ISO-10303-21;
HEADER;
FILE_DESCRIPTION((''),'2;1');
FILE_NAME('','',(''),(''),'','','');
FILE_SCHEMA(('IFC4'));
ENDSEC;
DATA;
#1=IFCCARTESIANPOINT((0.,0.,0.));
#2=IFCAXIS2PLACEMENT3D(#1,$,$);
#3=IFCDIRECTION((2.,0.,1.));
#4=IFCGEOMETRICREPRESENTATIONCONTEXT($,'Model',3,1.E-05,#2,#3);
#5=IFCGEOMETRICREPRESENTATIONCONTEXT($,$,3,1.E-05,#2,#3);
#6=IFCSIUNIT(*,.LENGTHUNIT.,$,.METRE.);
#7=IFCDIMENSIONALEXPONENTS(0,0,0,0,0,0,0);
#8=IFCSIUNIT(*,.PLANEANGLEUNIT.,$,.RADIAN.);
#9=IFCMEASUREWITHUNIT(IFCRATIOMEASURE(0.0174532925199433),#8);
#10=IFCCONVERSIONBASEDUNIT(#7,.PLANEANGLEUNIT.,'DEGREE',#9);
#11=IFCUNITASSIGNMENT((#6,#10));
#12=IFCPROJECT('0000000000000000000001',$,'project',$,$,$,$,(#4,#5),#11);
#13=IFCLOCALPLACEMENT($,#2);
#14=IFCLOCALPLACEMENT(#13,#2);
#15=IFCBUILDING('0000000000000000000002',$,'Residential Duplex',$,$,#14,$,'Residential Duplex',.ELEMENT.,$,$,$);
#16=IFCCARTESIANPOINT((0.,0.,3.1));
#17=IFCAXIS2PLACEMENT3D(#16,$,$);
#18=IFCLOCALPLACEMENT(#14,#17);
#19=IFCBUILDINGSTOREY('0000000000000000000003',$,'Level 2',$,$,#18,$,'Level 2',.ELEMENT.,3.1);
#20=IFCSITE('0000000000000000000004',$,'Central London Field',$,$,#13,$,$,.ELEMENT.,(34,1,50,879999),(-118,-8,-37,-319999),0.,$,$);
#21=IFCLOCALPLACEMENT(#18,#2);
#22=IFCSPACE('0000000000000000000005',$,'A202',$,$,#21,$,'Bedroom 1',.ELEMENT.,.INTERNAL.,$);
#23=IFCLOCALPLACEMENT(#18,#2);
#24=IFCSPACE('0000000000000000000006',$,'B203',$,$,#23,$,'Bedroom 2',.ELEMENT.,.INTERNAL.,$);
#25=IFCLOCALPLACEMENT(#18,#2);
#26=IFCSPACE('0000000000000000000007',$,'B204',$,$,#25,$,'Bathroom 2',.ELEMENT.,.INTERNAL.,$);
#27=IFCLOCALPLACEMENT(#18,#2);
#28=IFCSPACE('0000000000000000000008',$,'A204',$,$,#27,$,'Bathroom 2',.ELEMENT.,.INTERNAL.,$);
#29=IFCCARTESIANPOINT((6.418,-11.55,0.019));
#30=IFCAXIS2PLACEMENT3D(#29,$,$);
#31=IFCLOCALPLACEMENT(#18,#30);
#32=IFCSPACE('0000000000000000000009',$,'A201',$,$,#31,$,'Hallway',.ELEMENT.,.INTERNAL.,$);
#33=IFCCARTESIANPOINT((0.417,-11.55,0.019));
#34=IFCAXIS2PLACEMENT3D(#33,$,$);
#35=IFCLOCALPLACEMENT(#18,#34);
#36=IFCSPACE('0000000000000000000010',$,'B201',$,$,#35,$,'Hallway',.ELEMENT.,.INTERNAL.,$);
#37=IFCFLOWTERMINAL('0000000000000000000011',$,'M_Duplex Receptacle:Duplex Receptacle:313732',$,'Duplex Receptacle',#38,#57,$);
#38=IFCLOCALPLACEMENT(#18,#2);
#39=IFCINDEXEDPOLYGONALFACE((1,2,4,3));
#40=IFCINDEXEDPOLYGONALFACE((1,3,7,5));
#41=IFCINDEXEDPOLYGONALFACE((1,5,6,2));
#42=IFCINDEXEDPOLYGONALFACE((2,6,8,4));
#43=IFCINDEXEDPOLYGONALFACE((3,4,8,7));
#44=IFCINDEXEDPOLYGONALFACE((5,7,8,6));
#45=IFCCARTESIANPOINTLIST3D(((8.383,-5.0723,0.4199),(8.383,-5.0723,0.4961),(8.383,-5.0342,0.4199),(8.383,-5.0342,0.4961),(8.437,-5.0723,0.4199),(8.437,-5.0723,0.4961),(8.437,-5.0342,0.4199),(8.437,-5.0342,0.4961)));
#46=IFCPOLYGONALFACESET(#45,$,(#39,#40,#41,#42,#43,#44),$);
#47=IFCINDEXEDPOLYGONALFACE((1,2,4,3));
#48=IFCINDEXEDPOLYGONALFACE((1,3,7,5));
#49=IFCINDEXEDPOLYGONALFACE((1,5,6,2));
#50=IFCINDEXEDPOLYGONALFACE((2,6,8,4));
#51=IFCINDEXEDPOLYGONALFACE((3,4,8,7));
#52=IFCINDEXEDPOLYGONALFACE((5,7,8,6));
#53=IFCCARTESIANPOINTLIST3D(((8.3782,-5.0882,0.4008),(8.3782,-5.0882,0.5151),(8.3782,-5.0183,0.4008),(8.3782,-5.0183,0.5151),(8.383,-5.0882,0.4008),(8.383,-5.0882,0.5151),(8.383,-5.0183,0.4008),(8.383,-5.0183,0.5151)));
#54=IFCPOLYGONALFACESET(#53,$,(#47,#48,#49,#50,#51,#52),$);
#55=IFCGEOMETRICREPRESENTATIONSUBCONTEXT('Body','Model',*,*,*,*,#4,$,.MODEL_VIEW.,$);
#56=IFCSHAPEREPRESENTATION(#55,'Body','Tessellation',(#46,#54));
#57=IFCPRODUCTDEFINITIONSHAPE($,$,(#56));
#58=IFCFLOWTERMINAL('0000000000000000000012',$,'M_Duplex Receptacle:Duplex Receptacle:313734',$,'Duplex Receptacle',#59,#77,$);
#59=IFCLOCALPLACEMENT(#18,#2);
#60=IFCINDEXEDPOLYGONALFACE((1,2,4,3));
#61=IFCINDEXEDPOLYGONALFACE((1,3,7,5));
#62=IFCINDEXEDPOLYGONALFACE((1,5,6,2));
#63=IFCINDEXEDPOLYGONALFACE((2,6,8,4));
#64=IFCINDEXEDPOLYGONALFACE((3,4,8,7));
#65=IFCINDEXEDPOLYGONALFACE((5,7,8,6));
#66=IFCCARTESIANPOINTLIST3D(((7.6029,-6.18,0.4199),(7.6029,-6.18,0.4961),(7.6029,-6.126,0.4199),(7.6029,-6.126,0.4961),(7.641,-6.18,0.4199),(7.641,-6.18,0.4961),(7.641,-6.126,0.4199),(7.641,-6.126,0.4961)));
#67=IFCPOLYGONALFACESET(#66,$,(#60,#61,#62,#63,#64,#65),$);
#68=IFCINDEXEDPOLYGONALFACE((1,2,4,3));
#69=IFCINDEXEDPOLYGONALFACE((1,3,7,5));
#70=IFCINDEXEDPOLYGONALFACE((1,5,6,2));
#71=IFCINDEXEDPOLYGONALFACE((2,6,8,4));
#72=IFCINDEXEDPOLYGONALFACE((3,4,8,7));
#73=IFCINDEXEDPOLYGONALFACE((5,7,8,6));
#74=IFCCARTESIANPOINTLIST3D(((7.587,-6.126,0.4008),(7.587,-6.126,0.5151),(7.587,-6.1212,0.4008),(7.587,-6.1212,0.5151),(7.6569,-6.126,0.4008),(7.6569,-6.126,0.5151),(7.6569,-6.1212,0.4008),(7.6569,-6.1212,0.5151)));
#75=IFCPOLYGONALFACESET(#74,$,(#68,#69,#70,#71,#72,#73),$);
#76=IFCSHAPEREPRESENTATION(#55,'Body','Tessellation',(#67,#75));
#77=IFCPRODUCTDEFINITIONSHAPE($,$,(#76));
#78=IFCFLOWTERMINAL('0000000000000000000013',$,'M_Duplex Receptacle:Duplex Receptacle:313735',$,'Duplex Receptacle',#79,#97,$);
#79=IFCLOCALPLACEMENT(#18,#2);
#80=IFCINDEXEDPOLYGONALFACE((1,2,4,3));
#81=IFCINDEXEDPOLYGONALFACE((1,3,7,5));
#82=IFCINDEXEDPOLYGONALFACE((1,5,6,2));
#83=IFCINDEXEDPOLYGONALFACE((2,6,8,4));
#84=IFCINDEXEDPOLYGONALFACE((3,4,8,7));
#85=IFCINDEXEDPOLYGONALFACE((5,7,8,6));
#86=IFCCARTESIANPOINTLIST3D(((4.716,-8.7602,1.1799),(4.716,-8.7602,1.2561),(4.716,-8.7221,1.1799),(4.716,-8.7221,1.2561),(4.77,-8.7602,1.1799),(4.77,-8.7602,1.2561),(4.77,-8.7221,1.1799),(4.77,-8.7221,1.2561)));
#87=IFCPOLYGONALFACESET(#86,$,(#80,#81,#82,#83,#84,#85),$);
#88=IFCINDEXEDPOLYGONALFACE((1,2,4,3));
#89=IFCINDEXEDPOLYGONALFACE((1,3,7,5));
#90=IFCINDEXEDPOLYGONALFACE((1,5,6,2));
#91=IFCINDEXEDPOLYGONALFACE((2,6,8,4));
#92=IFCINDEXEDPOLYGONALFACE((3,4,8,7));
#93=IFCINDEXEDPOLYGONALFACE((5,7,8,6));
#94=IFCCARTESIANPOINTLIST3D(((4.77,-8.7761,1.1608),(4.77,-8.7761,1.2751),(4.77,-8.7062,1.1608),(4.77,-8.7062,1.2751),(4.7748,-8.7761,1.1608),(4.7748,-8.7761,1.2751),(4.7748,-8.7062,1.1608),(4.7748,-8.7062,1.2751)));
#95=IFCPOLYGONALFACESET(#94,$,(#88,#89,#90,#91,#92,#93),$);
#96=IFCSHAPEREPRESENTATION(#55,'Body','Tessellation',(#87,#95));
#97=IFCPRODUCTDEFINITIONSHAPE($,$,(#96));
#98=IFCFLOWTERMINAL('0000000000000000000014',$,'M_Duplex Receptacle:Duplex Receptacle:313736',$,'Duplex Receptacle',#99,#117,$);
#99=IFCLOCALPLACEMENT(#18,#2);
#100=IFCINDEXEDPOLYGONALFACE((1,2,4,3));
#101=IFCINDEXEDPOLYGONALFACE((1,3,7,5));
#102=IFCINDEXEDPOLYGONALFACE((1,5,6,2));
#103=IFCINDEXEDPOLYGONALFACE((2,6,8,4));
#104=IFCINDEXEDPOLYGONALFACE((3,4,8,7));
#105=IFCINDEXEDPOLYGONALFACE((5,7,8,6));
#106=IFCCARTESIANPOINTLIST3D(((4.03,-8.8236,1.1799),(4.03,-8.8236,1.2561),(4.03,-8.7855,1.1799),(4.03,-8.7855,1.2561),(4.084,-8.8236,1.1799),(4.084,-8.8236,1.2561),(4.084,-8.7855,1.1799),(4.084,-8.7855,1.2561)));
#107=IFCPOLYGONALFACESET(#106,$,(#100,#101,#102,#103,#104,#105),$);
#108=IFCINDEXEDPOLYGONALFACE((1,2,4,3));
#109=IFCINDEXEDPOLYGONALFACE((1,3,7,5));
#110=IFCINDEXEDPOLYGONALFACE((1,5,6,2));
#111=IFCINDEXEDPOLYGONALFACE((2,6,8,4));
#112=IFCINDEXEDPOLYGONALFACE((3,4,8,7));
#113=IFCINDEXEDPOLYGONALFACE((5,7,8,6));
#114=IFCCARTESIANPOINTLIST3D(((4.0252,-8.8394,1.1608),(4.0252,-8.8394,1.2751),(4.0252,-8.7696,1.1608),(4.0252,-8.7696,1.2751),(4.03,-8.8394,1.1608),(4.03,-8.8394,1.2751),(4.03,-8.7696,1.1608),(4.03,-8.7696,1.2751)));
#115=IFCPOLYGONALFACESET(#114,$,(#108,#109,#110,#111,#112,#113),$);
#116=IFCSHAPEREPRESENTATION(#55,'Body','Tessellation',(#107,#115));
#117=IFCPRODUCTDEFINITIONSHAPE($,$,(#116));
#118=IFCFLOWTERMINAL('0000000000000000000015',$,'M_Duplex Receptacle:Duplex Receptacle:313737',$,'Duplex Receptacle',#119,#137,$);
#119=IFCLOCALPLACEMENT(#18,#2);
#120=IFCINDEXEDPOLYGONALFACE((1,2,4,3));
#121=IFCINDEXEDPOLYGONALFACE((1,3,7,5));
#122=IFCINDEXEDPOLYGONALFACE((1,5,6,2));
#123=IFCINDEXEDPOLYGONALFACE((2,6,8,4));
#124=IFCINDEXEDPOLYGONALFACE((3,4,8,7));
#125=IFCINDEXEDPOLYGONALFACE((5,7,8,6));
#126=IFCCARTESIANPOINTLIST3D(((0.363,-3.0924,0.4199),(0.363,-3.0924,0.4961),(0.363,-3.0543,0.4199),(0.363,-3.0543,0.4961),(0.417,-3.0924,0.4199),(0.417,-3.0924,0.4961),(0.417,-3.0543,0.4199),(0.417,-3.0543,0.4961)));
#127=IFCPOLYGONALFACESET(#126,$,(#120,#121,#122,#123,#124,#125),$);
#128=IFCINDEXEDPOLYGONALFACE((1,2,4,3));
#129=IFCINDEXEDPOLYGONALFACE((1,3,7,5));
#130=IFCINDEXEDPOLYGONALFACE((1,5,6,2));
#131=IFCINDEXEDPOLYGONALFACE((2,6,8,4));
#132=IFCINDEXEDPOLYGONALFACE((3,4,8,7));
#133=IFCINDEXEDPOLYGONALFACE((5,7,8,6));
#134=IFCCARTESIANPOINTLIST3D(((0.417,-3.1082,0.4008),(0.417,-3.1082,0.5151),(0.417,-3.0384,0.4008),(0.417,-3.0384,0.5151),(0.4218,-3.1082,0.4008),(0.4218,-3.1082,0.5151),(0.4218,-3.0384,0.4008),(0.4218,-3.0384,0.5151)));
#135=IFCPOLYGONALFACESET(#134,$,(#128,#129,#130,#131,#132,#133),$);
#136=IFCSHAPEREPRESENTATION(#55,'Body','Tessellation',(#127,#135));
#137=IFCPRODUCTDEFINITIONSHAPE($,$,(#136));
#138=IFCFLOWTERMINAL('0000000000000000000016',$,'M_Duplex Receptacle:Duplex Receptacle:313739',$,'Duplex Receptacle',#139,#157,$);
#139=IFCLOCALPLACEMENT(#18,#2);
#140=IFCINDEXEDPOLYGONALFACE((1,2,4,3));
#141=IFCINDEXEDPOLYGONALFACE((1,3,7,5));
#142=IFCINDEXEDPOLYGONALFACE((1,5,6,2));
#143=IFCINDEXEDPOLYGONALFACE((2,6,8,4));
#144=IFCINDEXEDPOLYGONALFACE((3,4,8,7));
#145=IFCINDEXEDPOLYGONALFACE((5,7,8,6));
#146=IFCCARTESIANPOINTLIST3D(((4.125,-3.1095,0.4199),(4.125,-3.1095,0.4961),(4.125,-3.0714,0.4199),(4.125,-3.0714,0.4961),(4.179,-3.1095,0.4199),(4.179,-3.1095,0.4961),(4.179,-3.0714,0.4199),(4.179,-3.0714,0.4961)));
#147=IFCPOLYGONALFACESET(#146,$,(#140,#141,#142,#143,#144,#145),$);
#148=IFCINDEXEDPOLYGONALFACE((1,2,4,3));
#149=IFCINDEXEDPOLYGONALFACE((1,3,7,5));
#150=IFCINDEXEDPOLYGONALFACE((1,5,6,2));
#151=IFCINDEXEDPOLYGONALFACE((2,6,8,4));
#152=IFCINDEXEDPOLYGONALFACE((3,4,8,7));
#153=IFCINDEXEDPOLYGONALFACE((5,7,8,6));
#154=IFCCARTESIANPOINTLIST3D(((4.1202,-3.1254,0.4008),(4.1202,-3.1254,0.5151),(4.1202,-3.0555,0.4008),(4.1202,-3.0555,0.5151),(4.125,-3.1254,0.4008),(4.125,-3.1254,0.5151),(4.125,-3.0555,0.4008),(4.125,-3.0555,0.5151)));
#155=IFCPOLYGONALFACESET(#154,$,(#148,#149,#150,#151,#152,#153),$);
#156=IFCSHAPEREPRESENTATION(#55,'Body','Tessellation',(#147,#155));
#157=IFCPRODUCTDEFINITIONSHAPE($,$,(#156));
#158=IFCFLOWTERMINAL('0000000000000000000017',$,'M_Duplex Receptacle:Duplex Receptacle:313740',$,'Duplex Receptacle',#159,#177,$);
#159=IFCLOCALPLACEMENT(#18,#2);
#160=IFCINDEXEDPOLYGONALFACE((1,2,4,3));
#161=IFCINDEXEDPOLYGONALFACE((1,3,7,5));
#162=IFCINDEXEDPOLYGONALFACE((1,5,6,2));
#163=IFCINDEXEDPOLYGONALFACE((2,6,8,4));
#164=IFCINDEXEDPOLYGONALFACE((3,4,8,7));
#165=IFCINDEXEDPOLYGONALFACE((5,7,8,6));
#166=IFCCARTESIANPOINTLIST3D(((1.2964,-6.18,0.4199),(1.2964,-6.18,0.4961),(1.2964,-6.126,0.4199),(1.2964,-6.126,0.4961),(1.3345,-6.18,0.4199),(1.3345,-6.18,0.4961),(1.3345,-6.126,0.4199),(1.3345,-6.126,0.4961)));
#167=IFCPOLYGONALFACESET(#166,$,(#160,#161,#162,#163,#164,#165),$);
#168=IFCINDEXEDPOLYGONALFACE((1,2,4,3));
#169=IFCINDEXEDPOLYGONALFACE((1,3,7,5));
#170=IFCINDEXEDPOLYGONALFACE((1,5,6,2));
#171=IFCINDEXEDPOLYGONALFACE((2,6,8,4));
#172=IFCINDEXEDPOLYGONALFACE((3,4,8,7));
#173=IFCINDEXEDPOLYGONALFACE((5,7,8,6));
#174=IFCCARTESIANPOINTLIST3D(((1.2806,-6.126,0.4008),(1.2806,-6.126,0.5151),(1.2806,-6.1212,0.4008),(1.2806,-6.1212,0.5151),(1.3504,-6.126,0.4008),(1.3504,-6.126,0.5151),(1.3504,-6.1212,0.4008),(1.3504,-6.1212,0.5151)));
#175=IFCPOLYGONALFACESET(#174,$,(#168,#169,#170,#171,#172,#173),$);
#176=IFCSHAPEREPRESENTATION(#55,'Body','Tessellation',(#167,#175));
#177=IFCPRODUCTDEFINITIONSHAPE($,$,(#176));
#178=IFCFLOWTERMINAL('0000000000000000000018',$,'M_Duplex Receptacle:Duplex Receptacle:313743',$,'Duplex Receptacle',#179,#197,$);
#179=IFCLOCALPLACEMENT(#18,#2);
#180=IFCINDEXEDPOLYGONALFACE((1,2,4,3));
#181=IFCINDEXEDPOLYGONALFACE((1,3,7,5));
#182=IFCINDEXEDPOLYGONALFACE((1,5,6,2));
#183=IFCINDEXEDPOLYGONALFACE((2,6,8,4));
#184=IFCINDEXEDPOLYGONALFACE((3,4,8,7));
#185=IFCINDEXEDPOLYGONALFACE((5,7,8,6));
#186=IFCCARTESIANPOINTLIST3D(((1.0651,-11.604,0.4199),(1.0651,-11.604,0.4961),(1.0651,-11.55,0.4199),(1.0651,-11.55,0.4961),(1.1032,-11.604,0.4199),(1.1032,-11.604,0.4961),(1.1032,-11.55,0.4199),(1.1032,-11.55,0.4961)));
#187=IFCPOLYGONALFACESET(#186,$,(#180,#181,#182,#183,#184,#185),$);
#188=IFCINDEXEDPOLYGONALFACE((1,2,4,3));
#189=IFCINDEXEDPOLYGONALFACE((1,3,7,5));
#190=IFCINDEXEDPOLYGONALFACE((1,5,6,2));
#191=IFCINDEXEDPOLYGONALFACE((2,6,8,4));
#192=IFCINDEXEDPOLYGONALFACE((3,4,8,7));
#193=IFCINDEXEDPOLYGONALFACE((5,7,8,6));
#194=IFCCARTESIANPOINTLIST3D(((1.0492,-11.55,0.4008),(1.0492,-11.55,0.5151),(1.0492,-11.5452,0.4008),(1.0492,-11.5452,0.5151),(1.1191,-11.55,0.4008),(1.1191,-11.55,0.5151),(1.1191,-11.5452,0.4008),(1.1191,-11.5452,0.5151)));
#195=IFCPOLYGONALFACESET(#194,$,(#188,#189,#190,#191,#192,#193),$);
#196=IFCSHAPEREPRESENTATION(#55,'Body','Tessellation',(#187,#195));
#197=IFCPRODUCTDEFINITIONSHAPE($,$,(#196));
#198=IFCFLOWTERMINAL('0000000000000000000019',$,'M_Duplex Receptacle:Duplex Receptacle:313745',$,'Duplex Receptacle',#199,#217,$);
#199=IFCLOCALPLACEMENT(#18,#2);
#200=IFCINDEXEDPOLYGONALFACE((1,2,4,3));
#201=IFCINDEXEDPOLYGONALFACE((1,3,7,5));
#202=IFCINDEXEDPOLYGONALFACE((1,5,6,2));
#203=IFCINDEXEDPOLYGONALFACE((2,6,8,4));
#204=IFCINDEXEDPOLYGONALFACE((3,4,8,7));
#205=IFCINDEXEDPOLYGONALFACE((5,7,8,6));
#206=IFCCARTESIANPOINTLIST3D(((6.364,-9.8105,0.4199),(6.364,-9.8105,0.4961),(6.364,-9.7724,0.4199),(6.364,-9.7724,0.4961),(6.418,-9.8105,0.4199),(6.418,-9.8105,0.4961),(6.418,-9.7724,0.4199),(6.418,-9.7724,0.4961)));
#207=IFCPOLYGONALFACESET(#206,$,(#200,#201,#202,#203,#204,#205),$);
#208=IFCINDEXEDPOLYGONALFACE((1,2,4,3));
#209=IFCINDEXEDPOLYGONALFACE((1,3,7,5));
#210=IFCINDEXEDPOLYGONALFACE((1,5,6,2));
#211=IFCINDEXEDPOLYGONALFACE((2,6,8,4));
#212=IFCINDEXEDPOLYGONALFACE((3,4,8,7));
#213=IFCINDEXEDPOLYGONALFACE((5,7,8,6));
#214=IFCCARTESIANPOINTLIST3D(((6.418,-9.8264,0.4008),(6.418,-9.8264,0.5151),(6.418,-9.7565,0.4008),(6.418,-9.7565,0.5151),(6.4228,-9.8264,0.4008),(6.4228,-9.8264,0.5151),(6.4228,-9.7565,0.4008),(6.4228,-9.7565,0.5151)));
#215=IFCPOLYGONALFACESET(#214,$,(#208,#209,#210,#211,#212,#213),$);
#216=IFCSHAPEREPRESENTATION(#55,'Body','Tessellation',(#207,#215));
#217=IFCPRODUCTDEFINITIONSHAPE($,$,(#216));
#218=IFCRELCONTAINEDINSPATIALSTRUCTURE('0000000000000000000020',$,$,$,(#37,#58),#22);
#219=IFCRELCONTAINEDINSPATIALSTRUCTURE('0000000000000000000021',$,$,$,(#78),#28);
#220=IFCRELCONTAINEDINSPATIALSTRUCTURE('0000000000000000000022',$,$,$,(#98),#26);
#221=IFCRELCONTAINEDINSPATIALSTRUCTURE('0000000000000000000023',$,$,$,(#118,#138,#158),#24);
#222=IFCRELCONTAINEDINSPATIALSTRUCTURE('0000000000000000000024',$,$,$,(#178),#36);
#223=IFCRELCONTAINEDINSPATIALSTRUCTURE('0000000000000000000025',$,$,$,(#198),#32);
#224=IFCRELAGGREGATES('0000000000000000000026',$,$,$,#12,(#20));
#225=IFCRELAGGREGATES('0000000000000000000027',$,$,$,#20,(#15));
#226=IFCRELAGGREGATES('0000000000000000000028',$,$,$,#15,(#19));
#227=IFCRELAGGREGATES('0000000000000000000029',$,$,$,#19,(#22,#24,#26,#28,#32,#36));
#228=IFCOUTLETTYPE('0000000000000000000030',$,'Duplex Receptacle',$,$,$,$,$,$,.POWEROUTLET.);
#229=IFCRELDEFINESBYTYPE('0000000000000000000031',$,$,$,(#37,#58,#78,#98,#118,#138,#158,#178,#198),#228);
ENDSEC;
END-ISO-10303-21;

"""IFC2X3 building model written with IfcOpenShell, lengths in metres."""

from ifc_helpers import new_model, entity, si_unit, converted_unit, direction, frame, frame_2d, origin, origin_2d_with_axis, place, context, subcontext, project, spatial, rectangle, extrude, source, transform, mapped, type_object, type_shapes, element, save


model = new_model("IFC2X3")

# Units and contexts
model_context = context("Model", 3, precision=1e-05, world=origin(), true_north=direction((2.0, 0.0, 1.0)))
context_of_model = context(None, 3, precision=1e-05, world=origin(), true_north=direction((2.0, 0.0, 1.0)))
body_context = subcontext(model_context, "Body", "Model", "MODEL_VIEW")
ifc_project = project(units=[si_unit("LENGTHUNIT", "METRE"), converted_unit("PLANEANGLEUNIT", "DEGREE", entity("IfcRatioMeasure", 0.0174532925199433), si_unit("PLANEANGLEUNIT", "RADIAN"), dimensions=[0, 0, 0, 0, 0, 0, 0])], contexts=[model_context, context_of_model])

# Site, building, storey, space
site_placement = place(None, origin())
site = spatial("IfcSite", under=ifc_project, at=site_placement, Name="Central London Field", CompositionType="ELEMENT", RefLatitude=(34, 1, 50, 879999), RefLongitude=(-118, -8, -37, -319999), RefElevation=0.0)
building_placement = place(site_placement, origin())
building = spatial("IfcBuilding", under=site, at=building_placement, Name="Residential Duplex", LongName="Residential Duplex", CompositionType="ELEMENT")
storey_placement = place(building_placement, frame((0.0, 0.0, 3.1)))
storey = spatial("IfcBuildingStorey", under=building, at=storey_placement, Name="Level 2", LongName="Level 2", CompositionType="ELEMENT", Elevation=3.1)
space_1_placement = place(storey_placement, origin())
space_1 = spatial("IfcSpace", under=storey, at=space_1_placement, Name="A202", LongName="Bedroom 1", CompositionType="ELEMENT", InteriorOrExteriorSpace="INTERNAL")

# Shared definitions
space_2_placement = place(storey_placement, origin())
space_2 = spatial("IfcSpace", under=storey, at=space_2_placement, Name="B203", LongName="Bedroom 2", CompositionType="ELEMENT", InteriorOrExteriorSpace="INTERNAL")

# Shared definitions
space_3_placement = place(storey_placement, origin())
space_3 = spatial("IfcSpace", under=storey, at=space_3_placement, Name="B204", LongName="Bathroom 2", CompositionType="ELEMENT", InteriorOrExteriorSpace="INTERNAL")

# Shared definitions
space_4_placement = place(storey_placement, origin())
space_4 = spatial("IfcSpace", under=storey, at=space_4_placement, Name="A204", LongName="Bathroom 2", CompositionType="ELEMENT", InteriorOrExteriorSpace="INTERNAL")

# Shared definitions
space_5_placement = place(storey_placement, frame((6.418, -11.55, 0.019)))
space_5 = spatial("IfcSpace", under=storey, at=space_5_placement, Name="A201", LongName="Hallway", CompositionType="ELEMENT", InteriorOrExteriorSpace="INTERNAL")

# Shared definitions
space_6_placement = place(storey_placement, frame((0.417, -11.55, 0.019)))
space_6 = spatial("IfcSpace", under=storey, at=space_6_placement, Name="B201", LongName="Hallway", CompositionType="ELEMENT", InteriorOrExteriorSpace="INTERNAL")

# Flow terminals
outlet_type = type_object("IfcOutletType", Name="Duplex Receptacle", PredefinedType="POWEROUTLET")
shared_shape_1 = source(origin(), body_context, "Body", "SweptSolid", [
    extrude(rectangle(XDim=0.0381, YDim=0.0762, at=origin_2d_with_axis()), frame((0.0, 0.0, -0.054), z_axis=(0.0, 0.0, 1.0), x_axis=(-1.0, 0.0, 0.0)), (0.0, 0.0, 1.0), 0.054),
    extrude(rectangle(XDim=0.0698, YDim=0.1143, at=frame_2d((0.0, 0.0), x_axis=(1.0, 0.0))), frame((0.0, 0.0, 0.0), z_axis=(0.0, 0.0, 1.0), x_axis=(-1.0, 0.0, 0.0)), (0.0, 0.0, 1.0), 0.0048),
])
type_shapes(outlet_type, [shared_shape_1])
for number, where, z_axis, x_axis, name in (
    (1, (8.383, -5.0533, 0.458), (-1.0, 0.0, 0.0), (0.0, -1.0, 0.0), "M_Duplex Receptacle:Duplex Receptacle:313732"),
    (2, (7.622, -6.126, 0.458), (0.0, 1.0, 0.0), (-1.0, 0.0, 0.0), "M_Duplex Receptacle:Duplex Receptacle:313734"),
):
    element("IfcFlowTerminal", number, at=place(space_1_placement, frame(where, z_axis=z_axis, x_axis=x_axis)), inside=space_1, type_object=outlet_type, Name=name, ObjectType="Duplex Receptacle", context=body_context, shape_type="MappedRepresentation", body=[
        mapped(shared_shape_1, transform((0.0, 0.0, 0.0), scale=1.0)),
    ])
flow_terminal_1_placement = place(space_4_placement, frame((4.77, -8.7412, 1.218), z_axis=(1.0, 0.0, 0.0), x_axis=(0.0, 1.0, 0.0)))
element("IfcFlowTerminal", 3, at=flow_terminal_1_placement, inside=space_4, type_object=outlet_type, Name="M_Duplex Receptacle:Duplex Receptacle:313735", ObjectType="Duplex Receptacle", context=body_context, shape_type="MappedRepresentation", body=[
    mapped(shared_shape_1, transform((0.0, 0.0, 0.0), scale=1.0)),
])
flow_terminal_2_placement = place(space_3_placement, frame((4.03, -8.8045, 1.218), z_axis=(-1.0, 0.0, 0.0), x_axis=(0.0, -1.0, 0.0)))
element("IfcFlowTerminal", 4, at=flow_terminal_2_placement, inside=space_3, type_object=outlet_type, Name="M_Duplex Receptacle:Duplex Receptacle:313736", ObjectType="Duplex Receptacle", context=body_context, shape_type="MappedRepresentation", body=[
    mapped(shared_shape_1, transform((0.0, 0.0, 0.0), scale=1.0)),
])
for number, where, z_axis, x_axis, name in (
    (5, (0.417, -3.0733, 0.458), (1.0, 0.0, 0.0), (0.0, 1.0, 0.0), "M_Duplex Receptacle:Duplex Receptacle:313737"),
    (6, (4.125, -3.0905, 0.458), (-1.0, 0.0, 0.0), (0.0, -1.0, 0.0), "M_Duplex Receptacle:Duplex Receptacle:313739"),
    (7, (1.3155, -6.126, 0.458), (0.0, 1.0, 0.0), (-1.0, 0.0, 0.0), "M_Duplex Receptacle:Duplex Receptacle:313740"),
):
    element("IfcFlowTerminal", number, at=place(space_2_placement, frame(where, z_axis=z_axis, x_axis=x_axis)), inside=space_2, type_object=outlet_type, Name=name, ObjectType="Duplex Receptacle", context=body_context, shape_type="MappedRepresentation", body=[
        mapped(shared_shape_1, transform((0.0, 0.0, 0.0), scale=1.0)),
    ])
for number, where, z_axis, x_axis, name in (
    (8, (0.6671, 0.0, 0.439), (0.0, 1.0, 0.0), (-1.0, 0.0, 0.0), "M_Duplex Receptacle:Duplex Receptacle:313743"),
):
    element("IfcFlowTerminal", number, at=place(space_6_placement, frame(where, z_axis=z_axis, x_axis=x_axis)), inside=space_6, type_object=outlet_type, Name=name, ObjectType="Duplex Receptacle", context=body_context, shape_type="MappedRepresentation", body=[
        mapped(shared_shape_1, transform((0.0, 0.0, 0.0), scale=1.0)),
    ])
for number, where, z_axis, x_axis, name in (
    (9, (0.0, 1.7586, 0.439), (1.0, 0.0, 0.0), (0.0, 1.0, 0.0), "M_Duplex Receptacle:Duplex Receptacle:313745"),
):
    element("IfcFlowTerminal", number, at=place(space_5_placement, frame(where, z_axis=z_axis, x_axis=x_axis)), inside=space_5, type_object=outlet_type, Name=name, ObjectType="Duplex Receptacle", context=body_context, shape_type="MappedRepresentation", body=[
        mapped(shared_shape_1, transform((0.0, 0.0, 0.0), scale=1.0)),
    ])

save(model, "model.ifc")
